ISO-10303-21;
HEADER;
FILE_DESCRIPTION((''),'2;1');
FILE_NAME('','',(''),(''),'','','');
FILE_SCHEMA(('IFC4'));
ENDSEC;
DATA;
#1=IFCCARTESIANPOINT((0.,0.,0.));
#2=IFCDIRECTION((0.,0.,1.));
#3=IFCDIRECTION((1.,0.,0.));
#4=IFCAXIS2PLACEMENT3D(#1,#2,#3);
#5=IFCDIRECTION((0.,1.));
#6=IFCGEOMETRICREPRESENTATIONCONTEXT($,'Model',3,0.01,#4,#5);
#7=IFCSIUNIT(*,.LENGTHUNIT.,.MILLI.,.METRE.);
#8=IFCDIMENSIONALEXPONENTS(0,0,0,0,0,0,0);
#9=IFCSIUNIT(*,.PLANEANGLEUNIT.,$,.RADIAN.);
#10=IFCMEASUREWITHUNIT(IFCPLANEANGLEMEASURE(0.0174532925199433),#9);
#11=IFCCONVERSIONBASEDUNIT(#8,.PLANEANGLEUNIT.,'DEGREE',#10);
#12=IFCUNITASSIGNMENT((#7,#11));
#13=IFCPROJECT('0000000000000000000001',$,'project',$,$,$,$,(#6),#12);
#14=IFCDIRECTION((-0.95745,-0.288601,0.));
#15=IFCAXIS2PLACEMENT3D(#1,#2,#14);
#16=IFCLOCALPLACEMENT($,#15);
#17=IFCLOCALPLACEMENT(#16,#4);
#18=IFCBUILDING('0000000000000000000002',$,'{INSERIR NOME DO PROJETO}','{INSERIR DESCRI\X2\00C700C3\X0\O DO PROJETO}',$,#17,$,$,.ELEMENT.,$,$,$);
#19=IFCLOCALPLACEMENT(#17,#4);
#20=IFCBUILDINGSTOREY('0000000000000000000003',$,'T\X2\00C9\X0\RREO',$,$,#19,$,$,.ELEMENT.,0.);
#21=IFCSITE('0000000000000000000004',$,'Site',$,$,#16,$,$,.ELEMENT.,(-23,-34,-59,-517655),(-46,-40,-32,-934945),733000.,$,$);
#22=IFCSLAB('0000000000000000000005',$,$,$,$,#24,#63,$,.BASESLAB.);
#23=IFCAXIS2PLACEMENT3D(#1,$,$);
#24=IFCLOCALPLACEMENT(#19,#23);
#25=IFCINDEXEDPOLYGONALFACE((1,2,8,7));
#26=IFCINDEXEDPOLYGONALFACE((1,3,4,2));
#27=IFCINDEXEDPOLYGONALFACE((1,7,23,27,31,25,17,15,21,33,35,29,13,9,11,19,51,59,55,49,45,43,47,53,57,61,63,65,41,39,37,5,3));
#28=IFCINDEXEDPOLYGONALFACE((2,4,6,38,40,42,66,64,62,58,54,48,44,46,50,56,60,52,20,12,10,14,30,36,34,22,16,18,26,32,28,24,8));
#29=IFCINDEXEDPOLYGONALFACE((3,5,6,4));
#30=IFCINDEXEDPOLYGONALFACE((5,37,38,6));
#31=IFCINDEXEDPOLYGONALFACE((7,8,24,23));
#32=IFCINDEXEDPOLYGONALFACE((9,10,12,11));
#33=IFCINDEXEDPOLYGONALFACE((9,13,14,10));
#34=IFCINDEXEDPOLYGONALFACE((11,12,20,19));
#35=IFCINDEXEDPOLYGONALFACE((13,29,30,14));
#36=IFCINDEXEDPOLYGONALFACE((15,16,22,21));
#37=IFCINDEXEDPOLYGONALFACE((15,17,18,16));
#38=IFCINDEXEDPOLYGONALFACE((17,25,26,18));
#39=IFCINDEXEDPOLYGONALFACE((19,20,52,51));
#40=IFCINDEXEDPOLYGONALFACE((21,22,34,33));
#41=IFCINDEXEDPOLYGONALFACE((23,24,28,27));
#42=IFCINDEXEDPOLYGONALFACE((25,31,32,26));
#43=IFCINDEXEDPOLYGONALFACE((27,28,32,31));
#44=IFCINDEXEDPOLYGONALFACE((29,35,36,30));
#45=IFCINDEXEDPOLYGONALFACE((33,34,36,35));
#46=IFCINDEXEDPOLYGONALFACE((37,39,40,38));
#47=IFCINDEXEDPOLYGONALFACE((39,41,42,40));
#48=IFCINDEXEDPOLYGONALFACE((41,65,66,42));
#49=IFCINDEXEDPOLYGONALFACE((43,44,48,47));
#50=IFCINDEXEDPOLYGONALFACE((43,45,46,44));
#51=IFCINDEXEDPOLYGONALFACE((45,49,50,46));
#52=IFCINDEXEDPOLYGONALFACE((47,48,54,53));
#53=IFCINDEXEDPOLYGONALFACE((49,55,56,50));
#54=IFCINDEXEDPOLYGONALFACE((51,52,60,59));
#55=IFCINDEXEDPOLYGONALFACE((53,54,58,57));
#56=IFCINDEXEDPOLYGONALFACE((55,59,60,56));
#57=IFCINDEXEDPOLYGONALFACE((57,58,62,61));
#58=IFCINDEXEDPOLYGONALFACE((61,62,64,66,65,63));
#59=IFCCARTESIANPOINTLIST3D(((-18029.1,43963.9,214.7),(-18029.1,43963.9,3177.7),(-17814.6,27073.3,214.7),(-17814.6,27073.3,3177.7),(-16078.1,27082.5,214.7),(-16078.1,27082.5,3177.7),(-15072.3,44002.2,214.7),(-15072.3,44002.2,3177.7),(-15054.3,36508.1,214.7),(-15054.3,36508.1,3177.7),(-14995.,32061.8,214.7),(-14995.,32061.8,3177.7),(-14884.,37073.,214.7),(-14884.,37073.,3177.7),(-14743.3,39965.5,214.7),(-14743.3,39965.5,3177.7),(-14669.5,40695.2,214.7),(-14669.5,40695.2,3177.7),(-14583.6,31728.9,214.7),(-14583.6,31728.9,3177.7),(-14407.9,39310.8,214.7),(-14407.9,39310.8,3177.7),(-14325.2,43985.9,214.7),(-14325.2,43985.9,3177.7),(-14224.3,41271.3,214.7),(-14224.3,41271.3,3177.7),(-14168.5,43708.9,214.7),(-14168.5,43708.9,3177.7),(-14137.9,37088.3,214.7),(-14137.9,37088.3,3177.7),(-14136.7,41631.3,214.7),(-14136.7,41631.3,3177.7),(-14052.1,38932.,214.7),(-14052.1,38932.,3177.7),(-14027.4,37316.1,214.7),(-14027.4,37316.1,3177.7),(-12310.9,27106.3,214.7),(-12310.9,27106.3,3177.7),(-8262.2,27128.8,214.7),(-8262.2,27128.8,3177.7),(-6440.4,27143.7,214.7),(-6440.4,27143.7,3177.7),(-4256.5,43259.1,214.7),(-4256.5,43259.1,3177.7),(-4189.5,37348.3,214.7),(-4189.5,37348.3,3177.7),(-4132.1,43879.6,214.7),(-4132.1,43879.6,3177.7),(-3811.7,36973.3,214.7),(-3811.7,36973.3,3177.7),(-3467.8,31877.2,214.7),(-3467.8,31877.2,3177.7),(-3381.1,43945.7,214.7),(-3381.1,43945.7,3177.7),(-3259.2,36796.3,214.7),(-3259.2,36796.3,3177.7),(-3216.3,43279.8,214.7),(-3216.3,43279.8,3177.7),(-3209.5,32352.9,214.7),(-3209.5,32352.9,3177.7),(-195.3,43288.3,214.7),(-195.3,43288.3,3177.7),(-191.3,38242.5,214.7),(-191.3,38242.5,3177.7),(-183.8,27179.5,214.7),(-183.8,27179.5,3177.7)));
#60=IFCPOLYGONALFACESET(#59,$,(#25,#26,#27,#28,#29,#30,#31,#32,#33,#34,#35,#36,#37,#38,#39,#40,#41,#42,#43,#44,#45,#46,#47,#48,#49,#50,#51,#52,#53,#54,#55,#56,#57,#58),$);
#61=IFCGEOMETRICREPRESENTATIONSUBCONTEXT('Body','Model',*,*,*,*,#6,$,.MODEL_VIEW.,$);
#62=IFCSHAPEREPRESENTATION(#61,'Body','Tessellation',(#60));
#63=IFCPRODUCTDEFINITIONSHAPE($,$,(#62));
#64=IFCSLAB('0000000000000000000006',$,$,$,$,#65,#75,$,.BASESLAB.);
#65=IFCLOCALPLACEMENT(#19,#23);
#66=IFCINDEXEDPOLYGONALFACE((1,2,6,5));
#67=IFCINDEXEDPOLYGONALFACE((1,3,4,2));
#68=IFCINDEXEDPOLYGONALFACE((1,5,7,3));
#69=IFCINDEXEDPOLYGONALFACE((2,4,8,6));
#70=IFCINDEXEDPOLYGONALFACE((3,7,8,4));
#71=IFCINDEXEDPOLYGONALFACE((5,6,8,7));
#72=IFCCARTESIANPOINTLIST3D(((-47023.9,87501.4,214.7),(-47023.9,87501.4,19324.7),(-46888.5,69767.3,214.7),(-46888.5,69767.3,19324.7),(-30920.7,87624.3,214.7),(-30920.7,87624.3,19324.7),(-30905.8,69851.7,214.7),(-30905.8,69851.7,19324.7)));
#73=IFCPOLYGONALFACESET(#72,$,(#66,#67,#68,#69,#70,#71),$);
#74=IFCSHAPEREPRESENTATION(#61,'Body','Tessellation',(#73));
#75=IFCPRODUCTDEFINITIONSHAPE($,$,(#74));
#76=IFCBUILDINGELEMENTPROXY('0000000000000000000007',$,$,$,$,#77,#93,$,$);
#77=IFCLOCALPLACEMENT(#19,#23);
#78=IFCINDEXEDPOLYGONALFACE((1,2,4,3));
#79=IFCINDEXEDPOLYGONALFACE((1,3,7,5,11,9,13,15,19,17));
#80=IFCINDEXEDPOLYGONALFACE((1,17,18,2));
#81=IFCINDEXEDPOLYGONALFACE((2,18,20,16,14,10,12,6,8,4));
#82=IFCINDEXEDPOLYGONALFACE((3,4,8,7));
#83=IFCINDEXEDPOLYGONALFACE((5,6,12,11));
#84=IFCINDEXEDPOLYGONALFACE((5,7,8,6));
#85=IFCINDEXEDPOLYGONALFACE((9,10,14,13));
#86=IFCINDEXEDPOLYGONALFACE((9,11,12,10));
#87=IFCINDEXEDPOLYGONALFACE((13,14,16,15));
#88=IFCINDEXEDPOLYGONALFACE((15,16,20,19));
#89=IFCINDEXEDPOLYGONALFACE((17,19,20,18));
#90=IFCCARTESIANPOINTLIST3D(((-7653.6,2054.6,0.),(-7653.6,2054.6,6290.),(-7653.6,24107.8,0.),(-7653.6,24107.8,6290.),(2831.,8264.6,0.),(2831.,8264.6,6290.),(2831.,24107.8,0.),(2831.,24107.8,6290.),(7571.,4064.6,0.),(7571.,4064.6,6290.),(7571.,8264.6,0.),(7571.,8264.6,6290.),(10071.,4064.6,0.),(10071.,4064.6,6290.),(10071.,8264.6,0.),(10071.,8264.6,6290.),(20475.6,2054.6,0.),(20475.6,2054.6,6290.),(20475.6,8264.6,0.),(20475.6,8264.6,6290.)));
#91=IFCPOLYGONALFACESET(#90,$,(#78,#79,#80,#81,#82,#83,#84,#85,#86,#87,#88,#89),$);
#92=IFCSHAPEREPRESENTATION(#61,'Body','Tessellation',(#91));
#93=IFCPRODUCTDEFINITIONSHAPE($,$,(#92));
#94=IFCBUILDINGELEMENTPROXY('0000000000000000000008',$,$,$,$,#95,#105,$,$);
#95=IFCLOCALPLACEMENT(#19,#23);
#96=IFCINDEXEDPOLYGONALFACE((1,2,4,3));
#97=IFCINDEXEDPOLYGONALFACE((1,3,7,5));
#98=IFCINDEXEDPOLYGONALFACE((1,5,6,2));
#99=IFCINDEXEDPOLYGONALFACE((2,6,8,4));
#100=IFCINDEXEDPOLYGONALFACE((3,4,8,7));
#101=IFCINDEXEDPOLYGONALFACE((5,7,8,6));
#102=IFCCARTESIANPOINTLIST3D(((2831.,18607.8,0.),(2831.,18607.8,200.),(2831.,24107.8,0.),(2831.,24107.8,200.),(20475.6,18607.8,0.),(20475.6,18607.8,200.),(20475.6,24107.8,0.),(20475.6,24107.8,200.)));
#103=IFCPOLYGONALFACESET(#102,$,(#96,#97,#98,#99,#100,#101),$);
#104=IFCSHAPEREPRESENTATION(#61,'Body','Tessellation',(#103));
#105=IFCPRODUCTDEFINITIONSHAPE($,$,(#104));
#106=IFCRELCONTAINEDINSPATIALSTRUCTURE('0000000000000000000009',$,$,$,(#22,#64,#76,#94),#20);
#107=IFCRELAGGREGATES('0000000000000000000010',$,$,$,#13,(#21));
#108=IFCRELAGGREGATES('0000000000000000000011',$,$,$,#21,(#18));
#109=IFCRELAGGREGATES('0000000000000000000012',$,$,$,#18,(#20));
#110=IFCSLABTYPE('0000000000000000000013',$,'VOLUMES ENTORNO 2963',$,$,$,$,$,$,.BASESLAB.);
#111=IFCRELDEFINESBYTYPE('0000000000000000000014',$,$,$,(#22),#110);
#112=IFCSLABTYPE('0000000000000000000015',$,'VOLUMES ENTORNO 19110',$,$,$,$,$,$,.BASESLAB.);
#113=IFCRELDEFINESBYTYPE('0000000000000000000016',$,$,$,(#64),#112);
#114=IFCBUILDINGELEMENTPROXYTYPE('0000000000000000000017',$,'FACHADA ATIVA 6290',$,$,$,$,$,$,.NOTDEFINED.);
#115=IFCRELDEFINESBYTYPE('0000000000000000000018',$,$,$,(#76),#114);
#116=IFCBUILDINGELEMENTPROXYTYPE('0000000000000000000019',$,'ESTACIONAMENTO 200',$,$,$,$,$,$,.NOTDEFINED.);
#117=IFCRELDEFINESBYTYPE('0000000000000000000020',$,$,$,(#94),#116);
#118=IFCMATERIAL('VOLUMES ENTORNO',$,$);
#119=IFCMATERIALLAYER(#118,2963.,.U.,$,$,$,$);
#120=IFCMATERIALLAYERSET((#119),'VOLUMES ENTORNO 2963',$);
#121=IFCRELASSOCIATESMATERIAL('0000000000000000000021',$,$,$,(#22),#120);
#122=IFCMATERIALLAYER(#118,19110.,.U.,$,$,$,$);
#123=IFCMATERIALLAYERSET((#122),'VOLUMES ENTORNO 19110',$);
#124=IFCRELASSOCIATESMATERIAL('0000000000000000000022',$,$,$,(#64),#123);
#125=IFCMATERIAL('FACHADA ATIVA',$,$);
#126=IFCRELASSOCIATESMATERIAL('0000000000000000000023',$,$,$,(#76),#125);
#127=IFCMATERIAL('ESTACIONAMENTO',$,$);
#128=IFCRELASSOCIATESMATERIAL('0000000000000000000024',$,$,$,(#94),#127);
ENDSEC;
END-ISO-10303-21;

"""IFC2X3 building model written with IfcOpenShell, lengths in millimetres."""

from ifc_helpers import new_model, entity, si_unit, converted_unit, direction, frame, origin_with_axes, place, context, subcontext, project, spatial, polyline, outline, extrude, material, layer, layer_set, layer_usage, type_object, element, save


model = new_model("IFC2X3")

# Units and contexts
model_context = context("Model", 3, precision=0.01, world=origin_with_axes(), true_north=direction((0.0, 1.0)))
body_context = subcontext(model_context, "Body", "Model", "MODEL_VIEW")
ifc_project = project(units=[si_unit("LENGTHUNIT", "METRE", prefix="MILLI"), converted_unit("PLANEANGLEUNIT", "DEGREE", entity("IfcPlaneAngleMeasure", 0.0174532925199433), si_unit("PLANEANGLEUNIT", "RADIAN"), dimensions=[0, 0, 0, 0, 0, 0, 0])], contexts=[model_context])

# Site, building, storey
site_placement = place(None, frame((0.0, 0.0, 0.0), z_axis=(0.0, 0.0, 1.0), x_axis=(-0.95745, -0.288601, 0.0)))
site = spatial("IfcSite", under=ifc_project, at=site_placement, Name="Site", CompositionType="ELEMENT", RefLatitude=(-23, -34, -59, -517655), RefLongitude=(-46, -40, -32, -934945), RefElevation=733000.0)
building_placement = place(site_placement, origin_with_axes())
building = spatial("IfcBuilding", under=site, at=building_placement, Name="{INSERIR NOME DO PROJETO}", Description="{INSERIR DESCRIÇÃO DO PROJETO}", CompositionType="ELEMENT")
storey_placement = place(building_placement, origin_with_axes())
storey = spatial("IfcBuildingStorey", under=building, at=storey_placement, Name="TÉRREO", CompositionType="ELEMENT", Elevation=0.0)

# Slabs
ifc_material_1 = material(Name="VOLUMES ENTORNO")
ifc_layer_1 = layer(ifc_material_1, 2963.0, ventilated="UNKNOWN")
ifc_layer_set_1 = layer_set([ifc_layer_1], Name="VOLUMES ENTORNO 2963")
ifc_layer_usage_1 = layer_usage(ifc_layer_set_1, "AXIS3", "NEGATIVE", 2963.0)
slab_type_1 = type_object("IfcSlabType", Name="VOLUMES ENTORNO 2963", PredefinedType="BASESLAB")
slab_1_placement = place(storey_placement, frame((-195.3, 43288.3, 214.7), z_axis=(0.0, 0.0, 1.0), x_axis=(1.0, 0.0, 0.0)))
element("IfcSlab", 1, at=slab_1_placement, inside=storey, type_object=slab_type_1, material=ifc_layer_usage_1, PredefinedType="BASESLAB", context=body_context, shape_type="SweptSolid", body=[
    extrude(outline(polyline([(0.0, 0.0), (-3021.0, -8.5), (-3185.8, 657.4), (-3936.9, 591.3), (-4061.2, -29.2), (-3994.2, -5940.0), (-3616.4, -6315.0), (-3064.0, -6492.0), (-3014.2, -10935.4), (-3272.5, -11411.1), (-14388.3, -11559.4), (-14799.7, -11226.5), (-14859.0, -6780.2), (-14688.7, -6215.3), (-13942.6, -6200.0), (-13832.1, -5972.2), (-13856.8, -4356.3), (-14212.7, -3977.5), (-14548.0, -3322.8), (-14474.2, -2593.1), (-14029.1, -2017.0), (-13941.4, -1657.0), (-13973.2, 420.6), (-14129.9, 697.6), (-14877.0, 713.9), (-17833.9, 675.6), (-17619.4, -16215.0), (-15882.8, -16205.8), (-12115.7, -16182.0), (-8066.9, -16159.5), (-6245.1, -16144.6), (11.5, -16108.8), (3.9, -5045.8), (0.0, 0.0)])), origin_with_axes(), (0.0, 0.0, 1.0), 2963.0),
])
ifc_layer_2 = layer(ifc_material_1, 19110.0, ventilated="UNKNOWN")
ifc_layer_set_2 = layer_set([ifc_layer_2], Name="VOLUMES ENTORNO 19110")
ifc_layer_usage_2 = layer_usage(ifc_layer_set_2, "AXIS3", "NEGATIVE", 19110.0)
slab_type_2 = type_object("IfcSlabType", Name="VOLUMES ENTORNO 19110", PredefinedType="BASESLAB")
slab_2_placement = place(storey_placement, frame((-30905.8, 69851.7, 214.7), z_axis=(0.0, 0.0, 1.0), x_axis=(1.0, 0.0, 0.0)))
element("IfcSlab", 2, at=slab_2_placement, inside=storey, type_object=slab_type_2, material=ifc_layer_usage_2, PredefinedType="BASESLAB", context=body_context, shape_type="SweptSolid", body=[
    extrude(outline(polyline([(0.0, 0.0), (-14.9, 17772.7), (-16118.1, 17649.7), (-15982.7, -84.3), (0.0, 0.0)])), origin_with_axes(), (0.0, 0.0, 1.0), 19110.0),
])

# Building element proxies
ifc_material_2 = material(Name="FACHADA ATIVA")
building_element_proxy_type_1 = type_object("IfcBuildingElementProxyType", Name="FACHADA ATIVA 6290", PredefinedType="NOTDEFINED")
proxy_1_placement = place(storey_placement, frame((-7653.6, 24107.8, 0.0), z_axis=(0.0, 0.0, 1.0), x_axis=(1.0, 0.0, 0.0)))
element("IfcBuildingElementProxy", 3, at=proxy_1_placement, inside=storey, type_object=building_element_proxy_type_1, material=ifc_material_2, context=body_context, shape_type="SweptSolid", body=[
    extrude(outline(polyline([(0.0, 0.0), (0.0, -22053.2), (28129.2, -22053.2), (28129.2, -15843.2), (17724.6, -15843.2), (17724.6, -20043.2), (15224.6, -20043.2), (15224.6, -15843.2), (10484.6, -15843.2), (10484.6, 0.0), (0.0, 0.0)])), origin_with_axes(), (0.0, 0.0, 1.0), 6290.0),
])
ifc_material_3 = material(Name="ESTACIONAMENTO")
building_element_proxy_type_2 = type_object("IfcBuildingElementProxyType", Name="ESTACIONAMENTO 200", PredefinedType="NOTDEFINED")
proxy_2_placement = place(storey_placement, frame((2831.0, 18607.8, 0.0), z_axis=(0.0, 0.0, 1.0), x_axis=(1.0, 0.0, 0.0)))
element("IfcBuildingElementProxy", 4, at=proxy_2_placement, inside=storey, type_object=building_element_proxy_type_2, material=ifc_material_3, context=body_context, shape_type="SweptSolid", body=[
    extrude(outline(polyline([(0.0, 0.0), (17644.6, 0.0), (17644.6, 5500.0), (0.0, 5500.0), (0.0, 0.0)])), origin_with_axes(), (0.0, 0.0, 1.0), 200.0),
])

save(model, "model.ifc")
